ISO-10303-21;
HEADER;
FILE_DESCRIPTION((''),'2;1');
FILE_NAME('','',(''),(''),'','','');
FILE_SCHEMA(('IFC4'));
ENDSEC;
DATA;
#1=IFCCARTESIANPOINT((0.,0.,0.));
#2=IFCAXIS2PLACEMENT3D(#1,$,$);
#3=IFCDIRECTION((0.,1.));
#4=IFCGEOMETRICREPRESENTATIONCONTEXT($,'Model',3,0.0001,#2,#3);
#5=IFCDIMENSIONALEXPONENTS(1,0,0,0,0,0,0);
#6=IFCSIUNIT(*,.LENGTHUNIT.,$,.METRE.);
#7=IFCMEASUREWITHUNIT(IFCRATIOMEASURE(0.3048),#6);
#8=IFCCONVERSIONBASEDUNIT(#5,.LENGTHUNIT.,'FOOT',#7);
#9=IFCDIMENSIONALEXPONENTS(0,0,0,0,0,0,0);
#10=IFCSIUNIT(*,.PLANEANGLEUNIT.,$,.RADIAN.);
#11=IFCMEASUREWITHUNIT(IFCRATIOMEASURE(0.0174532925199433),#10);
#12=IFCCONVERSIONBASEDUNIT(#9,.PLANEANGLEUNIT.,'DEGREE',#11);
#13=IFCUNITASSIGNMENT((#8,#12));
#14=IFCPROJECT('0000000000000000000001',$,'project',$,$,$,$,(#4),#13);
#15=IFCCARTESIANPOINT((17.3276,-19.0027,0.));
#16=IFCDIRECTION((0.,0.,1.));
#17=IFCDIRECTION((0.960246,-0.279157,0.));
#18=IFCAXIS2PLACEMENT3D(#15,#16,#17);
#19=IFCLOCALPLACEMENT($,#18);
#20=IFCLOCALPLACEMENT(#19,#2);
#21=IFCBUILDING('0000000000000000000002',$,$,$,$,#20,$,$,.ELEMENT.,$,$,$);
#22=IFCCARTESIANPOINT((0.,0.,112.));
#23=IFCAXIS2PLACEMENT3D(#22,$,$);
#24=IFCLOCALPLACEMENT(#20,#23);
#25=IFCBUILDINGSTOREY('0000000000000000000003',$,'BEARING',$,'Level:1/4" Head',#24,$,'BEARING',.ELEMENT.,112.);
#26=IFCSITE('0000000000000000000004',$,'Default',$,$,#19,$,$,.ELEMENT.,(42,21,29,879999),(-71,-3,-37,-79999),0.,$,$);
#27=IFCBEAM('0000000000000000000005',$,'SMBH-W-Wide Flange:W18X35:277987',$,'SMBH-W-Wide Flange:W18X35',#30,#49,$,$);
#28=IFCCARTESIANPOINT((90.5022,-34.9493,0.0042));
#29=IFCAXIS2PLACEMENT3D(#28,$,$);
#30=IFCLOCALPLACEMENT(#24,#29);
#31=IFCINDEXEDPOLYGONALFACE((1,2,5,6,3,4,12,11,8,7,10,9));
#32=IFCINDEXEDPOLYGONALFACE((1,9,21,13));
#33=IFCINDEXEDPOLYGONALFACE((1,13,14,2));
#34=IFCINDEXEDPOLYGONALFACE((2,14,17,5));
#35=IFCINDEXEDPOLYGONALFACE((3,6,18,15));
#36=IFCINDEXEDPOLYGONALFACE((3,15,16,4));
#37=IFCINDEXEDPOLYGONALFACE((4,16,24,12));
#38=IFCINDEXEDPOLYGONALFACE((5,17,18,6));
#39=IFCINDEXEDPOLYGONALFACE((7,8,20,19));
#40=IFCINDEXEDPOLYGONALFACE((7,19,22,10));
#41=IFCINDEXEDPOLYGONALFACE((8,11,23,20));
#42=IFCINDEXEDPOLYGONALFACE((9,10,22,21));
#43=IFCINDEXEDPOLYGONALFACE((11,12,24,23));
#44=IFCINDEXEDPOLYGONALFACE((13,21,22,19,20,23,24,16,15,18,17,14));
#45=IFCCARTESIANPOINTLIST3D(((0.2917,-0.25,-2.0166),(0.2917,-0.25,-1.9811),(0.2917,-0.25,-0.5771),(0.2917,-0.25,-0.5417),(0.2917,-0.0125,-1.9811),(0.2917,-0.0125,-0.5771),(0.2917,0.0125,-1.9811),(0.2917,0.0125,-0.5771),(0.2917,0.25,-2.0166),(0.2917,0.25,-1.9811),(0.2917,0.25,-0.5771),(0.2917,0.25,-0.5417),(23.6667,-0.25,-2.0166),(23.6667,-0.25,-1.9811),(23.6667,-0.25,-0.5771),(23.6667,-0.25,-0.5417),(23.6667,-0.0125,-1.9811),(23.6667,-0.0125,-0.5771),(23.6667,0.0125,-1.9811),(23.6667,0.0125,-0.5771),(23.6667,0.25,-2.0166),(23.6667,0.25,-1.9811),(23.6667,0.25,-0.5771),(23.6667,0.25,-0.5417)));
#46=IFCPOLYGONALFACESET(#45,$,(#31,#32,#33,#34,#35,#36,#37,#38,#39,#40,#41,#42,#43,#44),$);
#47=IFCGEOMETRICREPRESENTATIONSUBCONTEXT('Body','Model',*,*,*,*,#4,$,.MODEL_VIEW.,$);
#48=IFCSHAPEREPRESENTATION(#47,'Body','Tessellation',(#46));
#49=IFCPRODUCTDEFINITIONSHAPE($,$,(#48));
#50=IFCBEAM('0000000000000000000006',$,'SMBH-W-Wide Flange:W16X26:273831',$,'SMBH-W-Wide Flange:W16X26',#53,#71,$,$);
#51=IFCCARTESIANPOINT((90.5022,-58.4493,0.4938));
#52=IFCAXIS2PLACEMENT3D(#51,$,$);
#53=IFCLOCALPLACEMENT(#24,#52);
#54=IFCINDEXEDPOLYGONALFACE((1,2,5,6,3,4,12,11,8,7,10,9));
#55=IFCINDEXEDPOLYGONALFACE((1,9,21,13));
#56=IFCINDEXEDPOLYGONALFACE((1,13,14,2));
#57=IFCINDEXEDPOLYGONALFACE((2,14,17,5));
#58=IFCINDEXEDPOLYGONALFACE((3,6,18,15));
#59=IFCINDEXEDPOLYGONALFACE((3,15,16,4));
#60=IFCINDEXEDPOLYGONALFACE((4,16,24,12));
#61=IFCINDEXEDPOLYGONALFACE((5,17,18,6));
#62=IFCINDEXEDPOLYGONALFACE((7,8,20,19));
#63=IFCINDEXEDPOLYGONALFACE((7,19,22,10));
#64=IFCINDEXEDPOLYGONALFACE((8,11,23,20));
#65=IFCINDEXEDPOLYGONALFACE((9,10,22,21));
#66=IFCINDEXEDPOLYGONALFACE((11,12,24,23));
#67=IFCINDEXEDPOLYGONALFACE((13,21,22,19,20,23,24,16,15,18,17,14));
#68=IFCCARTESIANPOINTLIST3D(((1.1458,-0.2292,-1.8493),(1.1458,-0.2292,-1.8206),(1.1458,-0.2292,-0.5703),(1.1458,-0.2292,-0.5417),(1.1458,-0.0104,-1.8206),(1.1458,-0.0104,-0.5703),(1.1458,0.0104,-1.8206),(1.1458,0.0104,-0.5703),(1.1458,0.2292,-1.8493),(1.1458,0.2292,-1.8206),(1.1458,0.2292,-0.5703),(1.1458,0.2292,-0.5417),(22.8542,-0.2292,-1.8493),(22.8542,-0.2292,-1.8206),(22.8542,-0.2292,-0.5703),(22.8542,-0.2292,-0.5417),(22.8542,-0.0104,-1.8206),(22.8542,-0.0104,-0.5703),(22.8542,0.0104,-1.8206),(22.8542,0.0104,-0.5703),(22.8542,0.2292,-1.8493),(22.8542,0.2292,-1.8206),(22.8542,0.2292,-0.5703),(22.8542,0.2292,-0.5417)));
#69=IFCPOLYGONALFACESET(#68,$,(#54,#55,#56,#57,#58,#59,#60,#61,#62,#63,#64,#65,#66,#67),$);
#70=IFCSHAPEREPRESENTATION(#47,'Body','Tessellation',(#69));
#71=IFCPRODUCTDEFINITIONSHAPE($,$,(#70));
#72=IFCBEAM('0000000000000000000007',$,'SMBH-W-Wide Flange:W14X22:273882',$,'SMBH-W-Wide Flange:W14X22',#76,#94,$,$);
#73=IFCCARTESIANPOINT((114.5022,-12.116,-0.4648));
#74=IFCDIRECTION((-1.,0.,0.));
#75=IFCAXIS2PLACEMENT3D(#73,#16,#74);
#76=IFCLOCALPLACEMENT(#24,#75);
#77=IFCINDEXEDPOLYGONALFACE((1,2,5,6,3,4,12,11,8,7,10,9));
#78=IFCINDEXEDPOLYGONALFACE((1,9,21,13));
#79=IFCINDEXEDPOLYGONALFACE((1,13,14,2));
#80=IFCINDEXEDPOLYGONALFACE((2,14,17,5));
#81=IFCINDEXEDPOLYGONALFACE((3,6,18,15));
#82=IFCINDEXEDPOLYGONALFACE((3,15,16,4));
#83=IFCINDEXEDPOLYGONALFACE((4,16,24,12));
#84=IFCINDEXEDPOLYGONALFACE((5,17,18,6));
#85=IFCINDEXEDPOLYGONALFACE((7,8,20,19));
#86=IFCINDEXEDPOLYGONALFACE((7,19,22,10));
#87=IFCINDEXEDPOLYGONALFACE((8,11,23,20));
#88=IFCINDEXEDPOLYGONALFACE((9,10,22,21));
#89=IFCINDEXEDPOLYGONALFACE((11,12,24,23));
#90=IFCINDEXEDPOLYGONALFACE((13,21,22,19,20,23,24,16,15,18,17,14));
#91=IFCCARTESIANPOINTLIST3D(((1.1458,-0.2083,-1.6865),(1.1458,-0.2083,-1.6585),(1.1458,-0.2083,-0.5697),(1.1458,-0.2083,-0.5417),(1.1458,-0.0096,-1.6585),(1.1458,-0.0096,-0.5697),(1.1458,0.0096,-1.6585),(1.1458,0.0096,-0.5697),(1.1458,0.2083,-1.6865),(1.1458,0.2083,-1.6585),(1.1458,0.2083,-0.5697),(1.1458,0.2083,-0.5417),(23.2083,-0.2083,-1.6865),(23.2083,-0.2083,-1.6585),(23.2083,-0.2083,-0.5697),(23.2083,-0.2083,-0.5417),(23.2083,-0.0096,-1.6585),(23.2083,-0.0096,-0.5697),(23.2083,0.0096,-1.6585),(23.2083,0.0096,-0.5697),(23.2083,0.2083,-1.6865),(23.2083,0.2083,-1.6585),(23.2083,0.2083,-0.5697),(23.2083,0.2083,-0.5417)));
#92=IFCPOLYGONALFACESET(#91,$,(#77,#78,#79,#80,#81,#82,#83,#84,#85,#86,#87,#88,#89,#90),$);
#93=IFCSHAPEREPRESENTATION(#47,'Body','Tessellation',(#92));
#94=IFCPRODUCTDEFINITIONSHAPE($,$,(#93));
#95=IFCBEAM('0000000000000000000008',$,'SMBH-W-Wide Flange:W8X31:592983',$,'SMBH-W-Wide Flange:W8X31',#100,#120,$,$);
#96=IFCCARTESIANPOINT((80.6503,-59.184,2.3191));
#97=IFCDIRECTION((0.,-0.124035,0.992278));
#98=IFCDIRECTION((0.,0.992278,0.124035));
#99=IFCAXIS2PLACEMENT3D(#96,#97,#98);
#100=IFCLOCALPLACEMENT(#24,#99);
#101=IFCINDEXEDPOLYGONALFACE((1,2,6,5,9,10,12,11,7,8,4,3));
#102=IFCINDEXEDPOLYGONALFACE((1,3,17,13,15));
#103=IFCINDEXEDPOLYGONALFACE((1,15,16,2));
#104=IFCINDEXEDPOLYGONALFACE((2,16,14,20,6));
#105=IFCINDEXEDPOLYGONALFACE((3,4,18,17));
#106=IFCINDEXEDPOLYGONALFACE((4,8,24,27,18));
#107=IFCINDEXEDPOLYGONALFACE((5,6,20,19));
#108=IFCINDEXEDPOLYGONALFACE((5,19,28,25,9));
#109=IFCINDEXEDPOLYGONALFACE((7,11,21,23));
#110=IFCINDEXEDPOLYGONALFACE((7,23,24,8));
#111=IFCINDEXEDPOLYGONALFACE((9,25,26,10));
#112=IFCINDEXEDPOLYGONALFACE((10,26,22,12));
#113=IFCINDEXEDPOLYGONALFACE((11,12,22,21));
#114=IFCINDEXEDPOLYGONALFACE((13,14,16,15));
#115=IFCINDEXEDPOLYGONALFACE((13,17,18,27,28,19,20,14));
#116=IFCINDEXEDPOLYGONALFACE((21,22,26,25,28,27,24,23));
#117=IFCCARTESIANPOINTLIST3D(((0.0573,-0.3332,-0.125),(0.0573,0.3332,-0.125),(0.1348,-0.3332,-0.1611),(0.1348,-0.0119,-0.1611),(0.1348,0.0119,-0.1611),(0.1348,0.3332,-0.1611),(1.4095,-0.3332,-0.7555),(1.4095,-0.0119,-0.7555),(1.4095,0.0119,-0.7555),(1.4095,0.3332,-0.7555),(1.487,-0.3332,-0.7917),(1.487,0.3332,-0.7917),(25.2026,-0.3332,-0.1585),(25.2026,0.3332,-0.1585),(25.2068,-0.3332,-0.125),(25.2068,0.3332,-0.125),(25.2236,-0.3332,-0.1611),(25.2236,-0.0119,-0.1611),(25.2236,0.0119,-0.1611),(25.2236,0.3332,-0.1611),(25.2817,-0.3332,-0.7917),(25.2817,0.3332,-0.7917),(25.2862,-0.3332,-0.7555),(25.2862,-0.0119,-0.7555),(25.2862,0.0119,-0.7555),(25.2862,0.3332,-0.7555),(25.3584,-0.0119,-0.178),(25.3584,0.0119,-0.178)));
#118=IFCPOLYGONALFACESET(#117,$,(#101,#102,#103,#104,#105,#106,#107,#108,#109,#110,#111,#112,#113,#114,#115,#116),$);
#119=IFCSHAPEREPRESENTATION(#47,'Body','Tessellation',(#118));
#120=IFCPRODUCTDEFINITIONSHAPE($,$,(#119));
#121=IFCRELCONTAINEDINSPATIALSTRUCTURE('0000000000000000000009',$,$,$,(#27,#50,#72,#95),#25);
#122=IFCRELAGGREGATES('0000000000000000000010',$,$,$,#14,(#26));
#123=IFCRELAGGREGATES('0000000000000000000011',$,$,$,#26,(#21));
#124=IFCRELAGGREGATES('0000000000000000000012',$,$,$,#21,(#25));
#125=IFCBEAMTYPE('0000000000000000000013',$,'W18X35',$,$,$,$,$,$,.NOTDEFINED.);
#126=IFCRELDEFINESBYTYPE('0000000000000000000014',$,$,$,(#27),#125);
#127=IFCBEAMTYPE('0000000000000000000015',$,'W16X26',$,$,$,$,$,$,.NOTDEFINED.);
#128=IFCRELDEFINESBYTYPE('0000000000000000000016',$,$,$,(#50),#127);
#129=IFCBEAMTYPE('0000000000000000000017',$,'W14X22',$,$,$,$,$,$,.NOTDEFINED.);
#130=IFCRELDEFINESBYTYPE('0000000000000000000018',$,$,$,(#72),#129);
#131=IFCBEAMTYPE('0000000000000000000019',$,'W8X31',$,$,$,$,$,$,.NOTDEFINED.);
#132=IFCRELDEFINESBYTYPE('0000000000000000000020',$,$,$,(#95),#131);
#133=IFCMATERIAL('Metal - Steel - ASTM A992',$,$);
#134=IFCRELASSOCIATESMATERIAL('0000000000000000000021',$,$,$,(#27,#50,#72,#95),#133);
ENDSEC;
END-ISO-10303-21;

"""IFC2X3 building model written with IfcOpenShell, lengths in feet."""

from ifc_helpers import new_model, entity, si_unit, converted_unit, direction, frame, frame_2d, origin, place, context, subcontext, project, spatial, polyline, i_section, outline, extrude, clip, halfspace, bounded_halfspace, material, type_object, element, save


model = new_model("IFC2X3")

# Units and contexts
model_context = context("Model", 3, precision=0.0001, world=origin(), true_north=direction((0.0, 1.0)))
body_context = subcontext(model_context, "Body", "Model", "MODEL_VIEW")
ifc_project = project(units=[converted_unit("LENGTHUNIT", "FOOT", entity("IfcRatioMeasure", 0.3048), si_unit("LENGTHUNIT", "METRE"), dimensions=[1, 0, 0, 0, 0, 0, 0]), converted_unit("PLANEANGLEUNIT", "DEGREE", entity("IfcRatioMeasure", 0.0174532925199433), si_unit("PLANEANGLEUNIT", "RADIAN"), dimensions=[0, 0, 0, 0, 0, 0, 0])], contexts=[model_context])

# Site, building, storey
site_placement = place(None, frame((17.3276, -19.0027, 0.0), z_axis=(0.0, 0.0, 1.0), x_axis=(0.960246, -0.279157, 0.0)))
site = spatial("IfcSite", under=ifc_project, at=site_placement, Name="Default", CompositionType="ELEMENT", RefLatitude=(42, 21, 29, 879999), RefLongitude=(-71, -3, -37, -79999), RefElevation=0.0)
building_placement = place(site_placement, origin())
building = spatial("IfcBuilding", under=site, at=building_placement, CompositionType="ELEMENT")
storey_placement = place(building_placement, frame((0.0, 0.0, 112.0)))
storey = spatial("IfcBuildingStorey", under=building, at=storey_placement, Name="BEARING", ObjectType="Level:1/4\" Head", LongName="BEARING", CompositionType="ELEMENT", Elevation=112.0)

# Beams
ifc_material_1 = material(Name="Metal - Steel - ASTM A992")
beam_type_1 = type_object("IfcBeamType", Name="W18X35", PredefinedType="NOTDEFINED")
beam_1_placement = place(storey_placement, frame((90.5022, -34.9493, 0.0042)))
element("IfcBeam", 1, at=beam_1_placement, inside=storey, type_object=beam_type_1, material=ifc_material_1, Name="SMBH-W-Wide Flange:W18X35:277987", ObjectType="SMBH-W-Wide Flange:W18X35", context=body_context, shape_type="SweptSolid", body=[
    extrude(i_section(OverallWidth=0.5, OverallDepth=1.4749, WebThickness=0.0251, FlangeThickness=0.0355, at=frame_2d((0.0, 0.0), x_axis=(0.0, 1.0))), frame((0.2917, 0.0, -1.2791), z_axis=(1.0, 0.0, 0.0), x_axis=(0.0, 0.0, -1.0)), (0.0, 0.0, 1.0), 23.375),
])
beam_type_2 = type_object("IfcBeamType", Name="W16X26", PredefinedType="NOTDEFINED")
beam_2_placement = place(storey_placement, frame((90.5022, -58.4493, 0.4938)))
element("IfcBeam", 2, at=beam_2_placement, inside=storey, type_object=beam_type_2, material=ifc_material_1, Name="SMBH-W-Wide Flange:W16X26:273831", ObjectType="SMBH-W-Wide Flange:W16X26", context=body_context, shape_type="SweptSolid", body=[
    extrude(i_section(OverallWidth=0.4583, OverallDepth=1.3076, WebThickness=0.0208, FlangeThickness=0.0286, at=frame_2d((0.0, 0.0), x_axis=(0.0, 1.0))), frame((1.1458, 0.0, -1.1955), z_axis=(1.0, 0.0, 0.0), x_axis=(0.0, 0.0, -1.0)), (0.0, 0.0, 1.0), 21.7083),
])
beam_type_3 = type_object("IfcBeamType", Name="W14X22", PredefinedType="NOTDEFINED")
beam_3_placement = place(storey_placement, frame((114.5022, -12.116, -0.4648), z_axis=(0.0, 0.0, 1.0), x_axis=(-1.0, 0.0, 0.0)))
element("IfcBeam", 3, at=beam_3_placement, inside=storey, type_object=beam_type_3, material=ifc_material_1, Name="SMBH-W-Wide Flange:W14X22:273882", ObjectType="SMBH-W-Wide Flange:W14X22", context=body_context, shape_type="SweptSolid", body=[
    extrude(i_section(OverallWidth=0.4167, OverallDepth=1.1449, WebThickness=0.0192, FlangeThickness=0.028, at=frame_2d((0.0, 0.0), x_axis=(0.0, 1.0))), frame((1.1458, 0.0, -1.1141), z_axis=(1.0, 0.0, 0.0), x_axis=(0.0, 0.0, -1.0)), (0.0, 0.0, 1.0), 22.0625),
])
beam_type_4 = type_object("IfcBeamType", Name="W8X31", PredefinedType="NOTDEFINED")
beam_4_placement = place(storey_placement, frame((80.6503, -59.184, 2.3191), z_axis=(0.0, -0.124035, 0.992278), x_axis=(0.0, 0.992278, 0.124035)))
element("IfcBeam", 4, at=beam_4_placement, inside=storey, type_object=beam_type_4, material=ifc_material_1, Name="SMBH-W-Wide Flange:W8X31:592983", ObjectType="SMBH-W-Wide Flange:W8X31", context=body_context, shape_type="SweptSolid", body=[
    clip(clip(clip(clip(extrude(outline(polyline([(-0.3332, -0.2972), (-0.3332, -0.3333), (0.3332, -0.3333), (0.3332, -0.2972), (0.0119, -0.2972), (0.0119, 0.2972), (0.3332, 0.2972), (0.3332, 0.3333), (-0.3332, 0.3333), (-0.3332, 0.2972), (-0.0119, 0.2972), (-0.0119, -0.2972), (-0.3332, -0.2972)])), frame((0.0573, 0.0, -0.4583), z_axis=(-1.0, 0.0, 0.0), x_axis=(0.0, 1.0, 0.0)), (0.0, 0.0, -1.0), 25.3011), halfspace(frame((0.0573, 25.3738, -0.125), z_axis=(-0.422618, 0.0, -0.906308), x_axis=(0.0, -1.0, 0.0)), False)), bounded_halfspace(frame((25.2504, 5.5648, -1.0427), z_axis=(0.992278, 0.0, -0.124035), x_axis=(0.0, -1.0, 0.0)), False, frame((0.0573, 0.0, -0.4583), z_axis=(-1.0, 0.0, 0.0), x_axis=(0.0, 1.0, 0.0)), polyline([(0.0119, -0.2803), (-0.0119, -0.2803), (-0.0119, 0.2972), (-0.3332, 0.2972), (-0.3332, 0.3333), (0.3332, 0.3333), (0.3332, 0.2972), (0.0119, 0.2972), (0.0119, -0.2803)]))), bounded_halfspace(frame((25.2026, 5.5648, -0.1585), z_axis=(0.992278, 0.0, -0.124035), x_axis=(0.0, -1.0, 0.0)), False, frame((0.0573, 0.0, -0.4583), z_axis=(-1.0, 0.0, 0.0), x_axis=(0.0, 1.0, 0.0)), polyline([(-0.3332, -0.2998), (0.3332, -0.2998), (0.3332, -0.3333), (-0.3332, -0.3333), (-0.3332, -0.2998)]))), bounded_halfspace(frame((25.3584, 5.5648, -0.178), z_axis=(0.124035, 0.0, 0.992278), x_axis=(0.0, -1.0, 0.0)), False, frame((0.0573, 0.0, -0.4583), z_axis=(-1.0, 0.0, 0.0), x_axis=(0.0, 1.0, 0.0)), polyline([(-0.0119, -0.2803), (0.0119, -0.2803), (0.0119, -0.2972), (0.3332, -0.2972), (0.3332, -0.2998), (-0.3332, -0.2998), (-0.3332, -0.2972), (-0.0119, -0.2972), (-0.0119, -0.2803)]))),
])

save(model, "model.ifc")
